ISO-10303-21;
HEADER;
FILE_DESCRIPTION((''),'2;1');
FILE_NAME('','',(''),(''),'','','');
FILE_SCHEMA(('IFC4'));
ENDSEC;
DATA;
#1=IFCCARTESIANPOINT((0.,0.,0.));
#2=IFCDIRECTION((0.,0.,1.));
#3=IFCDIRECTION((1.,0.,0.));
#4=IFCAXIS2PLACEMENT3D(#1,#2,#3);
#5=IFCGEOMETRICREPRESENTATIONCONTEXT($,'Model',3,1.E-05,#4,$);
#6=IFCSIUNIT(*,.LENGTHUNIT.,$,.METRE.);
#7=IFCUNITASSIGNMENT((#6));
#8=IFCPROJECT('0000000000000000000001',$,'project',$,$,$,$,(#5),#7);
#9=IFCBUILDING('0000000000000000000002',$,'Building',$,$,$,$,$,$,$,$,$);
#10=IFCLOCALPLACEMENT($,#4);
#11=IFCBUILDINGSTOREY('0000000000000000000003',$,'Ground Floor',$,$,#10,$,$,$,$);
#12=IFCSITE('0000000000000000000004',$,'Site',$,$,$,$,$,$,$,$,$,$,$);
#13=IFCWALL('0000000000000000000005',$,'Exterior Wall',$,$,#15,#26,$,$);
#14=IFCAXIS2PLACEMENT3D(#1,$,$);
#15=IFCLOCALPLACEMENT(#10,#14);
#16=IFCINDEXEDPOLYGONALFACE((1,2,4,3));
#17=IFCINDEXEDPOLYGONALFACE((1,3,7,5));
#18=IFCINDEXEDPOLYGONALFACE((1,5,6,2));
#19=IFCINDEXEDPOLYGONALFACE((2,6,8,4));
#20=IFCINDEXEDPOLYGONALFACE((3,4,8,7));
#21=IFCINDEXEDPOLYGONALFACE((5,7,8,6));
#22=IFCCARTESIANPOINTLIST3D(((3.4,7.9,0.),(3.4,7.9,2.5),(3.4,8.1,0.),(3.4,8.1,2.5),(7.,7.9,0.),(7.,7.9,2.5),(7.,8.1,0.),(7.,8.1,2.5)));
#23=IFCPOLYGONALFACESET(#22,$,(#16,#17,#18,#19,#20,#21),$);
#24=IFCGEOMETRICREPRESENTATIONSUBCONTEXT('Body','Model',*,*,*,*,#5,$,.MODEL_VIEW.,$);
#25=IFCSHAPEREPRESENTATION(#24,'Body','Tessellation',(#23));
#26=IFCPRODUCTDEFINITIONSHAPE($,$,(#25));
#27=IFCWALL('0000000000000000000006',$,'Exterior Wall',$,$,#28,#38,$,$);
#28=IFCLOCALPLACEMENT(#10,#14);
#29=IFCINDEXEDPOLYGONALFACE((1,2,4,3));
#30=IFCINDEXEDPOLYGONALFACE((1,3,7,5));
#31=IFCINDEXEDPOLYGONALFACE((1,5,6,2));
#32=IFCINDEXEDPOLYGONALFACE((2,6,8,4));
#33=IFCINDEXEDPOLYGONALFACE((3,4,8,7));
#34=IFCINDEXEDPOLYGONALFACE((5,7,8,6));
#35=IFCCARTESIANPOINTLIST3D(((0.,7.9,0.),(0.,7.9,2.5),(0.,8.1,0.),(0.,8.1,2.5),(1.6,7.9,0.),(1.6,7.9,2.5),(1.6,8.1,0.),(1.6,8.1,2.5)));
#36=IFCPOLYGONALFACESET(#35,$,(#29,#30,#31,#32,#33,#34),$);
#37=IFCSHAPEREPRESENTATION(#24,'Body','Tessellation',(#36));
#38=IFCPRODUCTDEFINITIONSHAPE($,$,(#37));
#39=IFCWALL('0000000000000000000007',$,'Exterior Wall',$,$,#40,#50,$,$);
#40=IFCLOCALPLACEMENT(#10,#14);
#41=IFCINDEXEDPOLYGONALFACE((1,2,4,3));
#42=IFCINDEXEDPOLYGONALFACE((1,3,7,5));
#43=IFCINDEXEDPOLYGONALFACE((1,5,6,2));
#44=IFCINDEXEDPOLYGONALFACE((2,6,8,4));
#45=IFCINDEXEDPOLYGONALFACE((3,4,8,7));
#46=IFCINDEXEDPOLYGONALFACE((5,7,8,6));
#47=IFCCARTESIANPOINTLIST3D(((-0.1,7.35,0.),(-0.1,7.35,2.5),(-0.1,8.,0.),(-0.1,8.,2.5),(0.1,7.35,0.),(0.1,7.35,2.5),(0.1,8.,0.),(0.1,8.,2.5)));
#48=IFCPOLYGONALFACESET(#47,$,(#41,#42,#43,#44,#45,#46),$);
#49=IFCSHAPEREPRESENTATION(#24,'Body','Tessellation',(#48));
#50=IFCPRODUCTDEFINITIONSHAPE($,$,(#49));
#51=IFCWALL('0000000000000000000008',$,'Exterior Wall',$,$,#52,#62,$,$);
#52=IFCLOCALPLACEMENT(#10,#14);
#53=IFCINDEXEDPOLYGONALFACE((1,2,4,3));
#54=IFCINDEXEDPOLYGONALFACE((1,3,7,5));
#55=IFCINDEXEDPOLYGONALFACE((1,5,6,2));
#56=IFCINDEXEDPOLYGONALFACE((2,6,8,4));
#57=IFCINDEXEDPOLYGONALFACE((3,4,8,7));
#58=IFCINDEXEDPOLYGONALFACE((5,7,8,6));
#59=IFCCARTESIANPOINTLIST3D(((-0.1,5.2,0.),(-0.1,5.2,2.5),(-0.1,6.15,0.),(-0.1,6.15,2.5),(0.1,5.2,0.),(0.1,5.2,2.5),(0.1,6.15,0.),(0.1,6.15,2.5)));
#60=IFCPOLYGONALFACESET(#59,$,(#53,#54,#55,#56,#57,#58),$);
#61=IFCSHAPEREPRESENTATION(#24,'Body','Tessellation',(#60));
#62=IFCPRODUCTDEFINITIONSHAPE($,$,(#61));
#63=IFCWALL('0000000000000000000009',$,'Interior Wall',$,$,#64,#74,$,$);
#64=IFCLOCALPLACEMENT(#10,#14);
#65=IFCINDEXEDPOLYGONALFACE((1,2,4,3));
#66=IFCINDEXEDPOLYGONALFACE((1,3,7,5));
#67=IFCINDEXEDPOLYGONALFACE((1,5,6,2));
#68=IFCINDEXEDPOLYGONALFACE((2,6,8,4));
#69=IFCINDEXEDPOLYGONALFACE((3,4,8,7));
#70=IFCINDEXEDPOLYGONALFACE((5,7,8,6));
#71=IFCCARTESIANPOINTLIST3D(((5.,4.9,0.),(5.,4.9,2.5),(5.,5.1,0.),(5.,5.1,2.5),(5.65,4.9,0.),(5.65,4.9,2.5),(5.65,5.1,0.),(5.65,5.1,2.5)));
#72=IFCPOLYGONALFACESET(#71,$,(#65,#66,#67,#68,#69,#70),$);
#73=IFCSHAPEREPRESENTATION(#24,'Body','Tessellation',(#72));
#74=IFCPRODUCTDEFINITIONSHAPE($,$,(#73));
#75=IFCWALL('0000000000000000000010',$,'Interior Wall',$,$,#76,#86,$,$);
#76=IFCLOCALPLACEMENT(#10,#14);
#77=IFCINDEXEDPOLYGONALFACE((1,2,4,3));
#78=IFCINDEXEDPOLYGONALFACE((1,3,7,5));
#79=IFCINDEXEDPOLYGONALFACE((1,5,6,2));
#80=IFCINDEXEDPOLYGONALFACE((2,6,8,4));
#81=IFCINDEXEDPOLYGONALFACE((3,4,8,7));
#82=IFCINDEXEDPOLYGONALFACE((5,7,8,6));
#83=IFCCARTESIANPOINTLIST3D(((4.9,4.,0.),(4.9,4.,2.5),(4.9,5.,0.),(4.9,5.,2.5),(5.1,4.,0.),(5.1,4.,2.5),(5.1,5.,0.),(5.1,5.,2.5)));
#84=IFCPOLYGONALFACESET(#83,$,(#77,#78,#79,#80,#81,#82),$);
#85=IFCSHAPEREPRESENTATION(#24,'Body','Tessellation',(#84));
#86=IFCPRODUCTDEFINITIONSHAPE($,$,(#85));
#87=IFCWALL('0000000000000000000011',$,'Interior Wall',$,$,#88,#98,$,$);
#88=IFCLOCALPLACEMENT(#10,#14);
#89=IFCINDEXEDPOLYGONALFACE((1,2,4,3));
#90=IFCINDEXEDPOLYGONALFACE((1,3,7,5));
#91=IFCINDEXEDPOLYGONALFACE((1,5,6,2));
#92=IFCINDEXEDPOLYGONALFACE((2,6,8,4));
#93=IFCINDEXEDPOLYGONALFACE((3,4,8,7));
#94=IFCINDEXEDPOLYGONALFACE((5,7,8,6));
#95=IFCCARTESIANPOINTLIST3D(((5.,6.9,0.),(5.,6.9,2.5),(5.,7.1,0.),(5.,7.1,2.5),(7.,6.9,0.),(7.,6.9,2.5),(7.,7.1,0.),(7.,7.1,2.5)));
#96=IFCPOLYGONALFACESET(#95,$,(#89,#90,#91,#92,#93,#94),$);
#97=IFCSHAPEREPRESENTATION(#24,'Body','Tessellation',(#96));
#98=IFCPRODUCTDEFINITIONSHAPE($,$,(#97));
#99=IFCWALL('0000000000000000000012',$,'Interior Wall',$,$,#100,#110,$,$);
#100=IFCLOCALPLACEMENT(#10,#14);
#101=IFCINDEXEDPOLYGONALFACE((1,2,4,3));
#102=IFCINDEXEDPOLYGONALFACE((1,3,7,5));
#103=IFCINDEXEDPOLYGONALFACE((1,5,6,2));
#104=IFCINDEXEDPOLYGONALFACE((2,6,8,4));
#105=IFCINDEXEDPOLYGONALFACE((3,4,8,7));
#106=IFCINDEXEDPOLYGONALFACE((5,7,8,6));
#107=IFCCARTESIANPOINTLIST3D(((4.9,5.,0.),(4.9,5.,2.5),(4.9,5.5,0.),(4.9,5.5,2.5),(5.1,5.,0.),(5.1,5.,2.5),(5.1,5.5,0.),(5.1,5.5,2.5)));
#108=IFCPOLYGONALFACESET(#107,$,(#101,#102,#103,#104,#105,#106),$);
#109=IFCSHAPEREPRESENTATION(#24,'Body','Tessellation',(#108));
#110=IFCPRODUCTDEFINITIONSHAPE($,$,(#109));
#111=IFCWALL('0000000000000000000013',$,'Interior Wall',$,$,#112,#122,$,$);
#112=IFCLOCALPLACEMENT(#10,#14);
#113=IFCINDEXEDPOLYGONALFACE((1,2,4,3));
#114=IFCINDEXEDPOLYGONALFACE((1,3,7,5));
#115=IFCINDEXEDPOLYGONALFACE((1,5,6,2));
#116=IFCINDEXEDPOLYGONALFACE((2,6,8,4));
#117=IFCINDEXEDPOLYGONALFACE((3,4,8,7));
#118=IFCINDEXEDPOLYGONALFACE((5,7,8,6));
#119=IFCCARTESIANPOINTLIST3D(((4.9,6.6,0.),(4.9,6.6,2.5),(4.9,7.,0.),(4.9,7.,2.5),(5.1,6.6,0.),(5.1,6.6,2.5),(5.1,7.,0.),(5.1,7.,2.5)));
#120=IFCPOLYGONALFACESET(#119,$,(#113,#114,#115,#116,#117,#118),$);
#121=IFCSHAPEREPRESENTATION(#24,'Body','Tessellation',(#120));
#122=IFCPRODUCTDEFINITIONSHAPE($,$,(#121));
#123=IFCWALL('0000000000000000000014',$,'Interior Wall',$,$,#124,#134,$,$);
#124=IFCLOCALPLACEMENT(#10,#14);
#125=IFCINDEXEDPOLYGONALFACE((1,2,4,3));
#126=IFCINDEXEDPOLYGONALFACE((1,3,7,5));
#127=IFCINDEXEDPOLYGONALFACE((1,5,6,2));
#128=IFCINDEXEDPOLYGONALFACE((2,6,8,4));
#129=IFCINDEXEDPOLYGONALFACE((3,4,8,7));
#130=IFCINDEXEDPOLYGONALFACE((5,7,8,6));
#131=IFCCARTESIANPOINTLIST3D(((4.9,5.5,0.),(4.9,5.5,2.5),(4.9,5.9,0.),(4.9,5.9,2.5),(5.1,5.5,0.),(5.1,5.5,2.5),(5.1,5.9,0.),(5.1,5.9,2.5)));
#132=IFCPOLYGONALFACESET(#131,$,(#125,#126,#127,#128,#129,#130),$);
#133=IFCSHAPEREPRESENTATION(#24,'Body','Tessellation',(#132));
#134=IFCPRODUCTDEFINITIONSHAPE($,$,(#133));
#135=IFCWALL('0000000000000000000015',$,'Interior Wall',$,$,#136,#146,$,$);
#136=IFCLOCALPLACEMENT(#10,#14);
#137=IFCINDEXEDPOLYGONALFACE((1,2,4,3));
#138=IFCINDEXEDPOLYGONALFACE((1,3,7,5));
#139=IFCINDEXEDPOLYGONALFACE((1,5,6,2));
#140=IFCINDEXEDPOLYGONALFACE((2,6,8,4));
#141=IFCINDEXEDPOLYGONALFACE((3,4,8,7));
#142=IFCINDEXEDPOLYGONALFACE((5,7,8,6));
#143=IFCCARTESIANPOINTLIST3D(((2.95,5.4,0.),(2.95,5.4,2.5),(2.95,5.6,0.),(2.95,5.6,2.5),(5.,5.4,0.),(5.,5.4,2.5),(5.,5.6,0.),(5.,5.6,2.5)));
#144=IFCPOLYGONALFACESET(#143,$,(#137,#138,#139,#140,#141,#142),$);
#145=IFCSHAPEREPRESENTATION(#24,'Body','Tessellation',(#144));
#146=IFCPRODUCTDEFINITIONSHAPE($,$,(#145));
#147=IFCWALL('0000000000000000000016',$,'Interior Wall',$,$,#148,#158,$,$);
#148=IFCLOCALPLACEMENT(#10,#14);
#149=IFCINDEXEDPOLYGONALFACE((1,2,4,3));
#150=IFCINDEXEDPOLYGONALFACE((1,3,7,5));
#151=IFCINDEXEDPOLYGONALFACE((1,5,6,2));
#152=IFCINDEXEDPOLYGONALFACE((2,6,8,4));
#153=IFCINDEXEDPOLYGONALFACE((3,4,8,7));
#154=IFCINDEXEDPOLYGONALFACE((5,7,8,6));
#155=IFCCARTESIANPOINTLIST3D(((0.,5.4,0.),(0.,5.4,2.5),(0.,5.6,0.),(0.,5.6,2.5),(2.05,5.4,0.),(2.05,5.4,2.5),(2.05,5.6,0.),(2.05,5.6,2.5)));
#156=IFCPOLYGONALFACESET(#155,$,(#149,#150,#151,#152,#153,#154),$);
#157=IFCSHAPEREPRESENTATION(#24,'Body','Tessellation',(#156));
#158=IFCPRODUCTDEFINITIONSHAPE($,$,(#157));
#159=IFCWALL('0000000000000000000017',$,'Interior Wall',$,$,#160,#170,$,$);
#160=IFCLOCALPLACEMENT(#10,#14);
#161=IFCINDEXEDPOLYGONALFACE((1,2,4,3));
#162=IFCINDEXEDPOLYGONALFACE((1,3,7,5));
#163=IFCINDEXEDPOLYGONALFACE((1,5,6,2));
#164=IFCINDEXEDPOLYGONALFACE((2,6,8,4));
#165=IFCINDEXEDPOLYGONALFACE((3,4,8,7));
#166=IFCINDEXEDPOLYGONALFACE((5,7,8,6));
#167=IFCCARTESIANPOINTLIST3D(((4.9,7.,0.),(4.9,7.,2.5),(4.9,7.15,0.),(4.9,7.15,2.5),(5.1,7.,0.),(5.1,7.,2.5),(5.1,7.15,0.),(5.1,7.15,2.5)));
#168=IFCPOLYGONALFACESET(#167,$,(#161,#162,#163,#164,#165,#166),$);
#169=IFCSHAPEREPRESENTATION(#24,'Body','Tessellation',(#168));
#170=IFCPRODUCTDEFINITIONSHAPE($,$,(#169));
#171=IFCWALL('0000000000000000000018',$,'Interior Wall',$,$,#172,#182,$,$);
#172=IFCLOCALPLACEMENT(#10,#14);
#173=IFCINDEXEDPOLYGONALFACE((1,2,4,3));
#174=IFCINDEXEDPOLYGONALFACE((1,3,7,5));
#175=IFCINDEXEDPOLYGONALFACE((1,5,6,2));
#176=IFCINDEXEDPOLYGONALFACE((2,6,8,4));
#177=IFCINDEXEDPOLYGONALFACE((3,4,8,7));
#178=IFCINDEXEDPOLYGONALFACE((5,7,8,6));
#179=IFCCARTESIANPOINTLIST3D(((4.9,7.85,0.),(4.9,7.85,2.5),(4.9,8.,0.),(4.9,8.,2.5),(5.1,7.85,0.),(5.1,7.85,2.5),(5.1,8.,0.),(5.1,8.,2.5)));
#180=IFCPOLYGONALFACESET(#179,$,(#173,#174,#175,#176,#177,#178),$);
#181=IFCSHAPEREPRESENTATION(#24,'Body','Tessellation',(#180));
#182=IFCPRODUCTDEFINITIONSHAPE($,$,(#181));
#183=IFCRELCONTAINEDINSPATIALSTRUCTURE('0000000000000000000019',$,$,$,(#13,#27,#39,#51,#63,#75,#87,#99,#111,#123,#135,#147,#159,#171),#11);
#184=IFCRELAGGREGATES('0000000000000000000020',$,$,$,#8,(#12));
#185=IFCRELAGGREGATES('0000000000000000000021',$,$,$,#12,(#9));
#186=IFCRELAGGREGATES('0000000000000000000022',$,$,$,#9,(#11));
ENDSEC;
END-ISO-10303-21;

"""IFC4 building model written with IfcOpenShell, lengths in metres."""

from ifc_helpers import new_model, si_unit, frame, origin_with_axes, place, context, subcontext, project, spatial, indexed_curve, outline, extrude, element, save


model = new_model("IFC4")

# Units and contexts
model_context = context("Model", 3, precision=1e-05, world=origin_with_axes())
body_context = subcontext(model_context, "Body", "Model", "MODEL_VIEW")
ifc_project = project(units=[si_unit("LENGTHUNIT", "METRE")], contexts=[model_context])

# Site, building, storey
site = spatial("IfcSite", under=ifc_project, Name="Site")
building = spatial("IfcBuilding", under=site, Name="Building")
storey_placement = place(None, origin_with_axes())
storey = spatial("IfcBuildingStorey", under=building, at=storey_placement, Name="Ground Floor")

# Walls
wall_1_placement = place(storey_placement, frame((7.0, 8.0, 0.0), z_axis=(0.0, 0.0, 1.0), x_axis=(-1.0, 0.0, 0.0)))
element("IfcWall", 1, at=wall_1_placement, inside=storey, Name="Exterior Wall", context=body_context, shape_type="SweptSolid", body=[
    extrude(outline(indexed_curve([(0.0, 0.0), (0.0, 0.2), (3.6, 0.2), (3.6, 0.0), (0.0, 0.0)], self_intersect=False)), frame((0.0, -0.1, 0.0), z_axis=(0.0, 0.0, 1.0), x_axis=(1.0, 0.0, 0.0)), (0.0, 0.0, 1.0), 2.5),
])
wall_2_placement = place(storey_placement, frame((1.6, 8.0, 0.0), z_axis=(0.0, 0.0, 1.0), x_axis=(-1.0, 0.0, 0.0)))
element("IfcWall", 2, at=wall_2_placement, inside=storey, Name="Exterior Wall", context=body_context, shape_type="SweptSolid", body=[
    extrude(outline(indexed_curve([(0.0, 0.0), (0.0, 0.2), (1.6, 0.2), (1.6, 0.0), (0.0, 0.0)], self_intersect=False)), frame((0.0, -0.1, 0.0), z_axis=(0.0, 0.0, 1.0), x_axis=(1.0, 0.0, 0.0)), (0.0, 0.0, 1.0), 2.5),
])
wall_3_placement = place(storey_placement, frame((0.0, 8.0, 0.0), z_axis=(0.0, 0.0, 1.0), x_axis=(0.0, -1.0, 0.0)))
element("IfcWall", 3, at=wall_3_placement, inside=storey, Name="Exterior Wall", context=body_context, shape_type="SweptSolid", body=[
    extrude(outline(indexed_curve([(0.0, 0.0), (0.0, 0.2), (0.65, 0.2), (0.65, 0.0), (0.0, 0.0)], self_intersect=False)), frame((0.0, -0.1, 0.0), z_axis=(0.0, 0.0, 1.0), x_axis=(1.0, 0.0, 0.0)), (0.0, 0.0, 1.0), 2.5),
])
wall_4_placement = place(storey_placement, frame((0.0, 6.15, 0.0), z_axis=(0.0, 0.0, 1.0), x_axis=(0.0, -1.0, 0.0)))
element("IfcWall", 4, at=wall_4_placement, inside=storey, Name="Exterior Wall", context=body_context, shape_type="SweptSolid", body=[
    extrude(outline(indexed_curve([(0.0, 0.0), (0.0, 0.2), (0.95, 0.2), (0.95, 0.0), (0.0, 0.0)], self_intersect=False)), frame((0.0, -0.1, 0.0), z_axis=(0.0, 0.0, 1.0), x_axis=(1.0, 0.0, 0.0)), (0.0, 0.0, 1.0), 2.5),
])
wall_5_placement = place(storey_placement, frame((5.65, 5.0, 0.0), z_axis=(0.0, 0.0, 1.0), x_axis=(-1.0, 0.0, 0.0)))
element("IfcWall", 5, at=wall_5_placement, inside=storey, Name="Interior Wall", context=body_context, shape_type="SweptSolid", body=[
    extrude(outline(indexed_curve([(0.0, 0.0), (0.0, 0.2), (0.65, 0.2), (0.65, 0.0), (0.0, 0.0)], self_intersect=False)), frame((0.0, -0.1, 0.0), z_axis=(0.0, 0.0, 1.0), x_axis=(1.0, 0.0, 0.0)), (0.0, 0.0, 1.0), 2.5),
])
wall_6_placement = place(storey_placement, frame((5.0, 5.0, 0.0), z_axis=(0.0, 0.0, 1.0), x_axis=(0.0, -1.0, 0.0)))
element("IfcWall", 6, at=wall_6_placement, inside=storey, Name="Interior Wall", context=body_context, shape_type="SweptSolid", body=[
    extrude(outline(indexed_curve([(0.0, 0.0), (0.0, 0.2), (1.0, 0.2), (1.0, 0.0), (0.0, 0.0)], self_intersect=False)), frame((0.0, -0.1, 0.0), z_axis=(0.0, 0.0, 1.0), x_axis=(1.0, 0.0, 0.0)), (0.0, 0.0, 1.0), 2.5),
])
wall_7_placement = place(storey_placement, frame((7.0, 7.0, 0.0), z_axis=(0.0, 0.0, 1.0), x_axis=(-1.0, 0.0, 0.0)))
element("IfcWall", 7, at=wall_7_placement, inside=storey, Name="Interior Wall", context=body_context, shape_type="SweptSolid", body=[
    extrude(outline(indexed_curve([(0.0, 0.0), (0.0, 0.2), (2.0, 0.2), (2.0, 0.0), (0.0, 0.0)], self_intersect=False)), frame((0.0, -0.1, 0.0), z_axis=(0.0, 0.0, 1.0), x_axis=(1.0, 0.0, 0.0)), (0.0, 0.0, 1.0), 2.5),
])
wall_8_placement = place(storey_placement, frame((5.0, 5.5, 0.0), z_axis=(0.0, 0.0, 1.0), x_axis=(0.0, -1.0, 0.0)))
element("IfcWall", 8, at=wall_8_placement, inside=storey, Name="Interior Wall", context=body_context, shape_type="SweptSolid", body=[
    extrude(outline(indexed_curve([(0.0, 0.0), (0.0, 0.2), (0.5, 0.2), (0.5, 0.0), (0.0, 0.0)], self_intersect=False)), frame((0.0, -0.1, 0.0), z_axis=(0.0, 0.0, 1.0), x_axis=(1.0, 0.0, 0.0)), (0.0, 0.0, 1.0), 2.5),
])
for number, where, z_axis, x_axis, name in (
    (9, (5.0, 7.0, 0.0), (0.0, 0.0, 1.0), (0.0, -1.0, 0.0), "Interior Wall"),
    (10, (5.0, 5.9, 0.0), (0.0, 0.0, 1.0), (0.0, -1.0, 0.0), "Interior Wall"),
):
    element("IfcWall", number, at=place(storey_placement, frame(where, z_axis=z_axis, x_axis=x_axis)), inside=storey, Name=name, context=body_context, shape_type="SweptSolid", body=[
        extrude(outline(indexed_curve([(0.0, 0.0), (0.0, 0.2), (0.4, 0.2), (0.4, 0.0), (0.0, 0.0)], self_intersect=False)), frame((0.0, -0.1, 0.0), z_axis=(0.0, 0.0, 1.0), x_axis=(1.0, 0.0, 0.0)), (0.0, 0.0, 1.0), 2.5),
    ])
for number, where, z_axis, x_axis, name in (
    (11, (5.0, 5.5, 0.0), (0.0, 0.0, 1.0), (-1.0, 0.0, 0.0), "Interior Wall"),
    (12, (2.05, 5.5, 0.0), (0.0, 0.0, 1.0), (-1.0, 0.0, 0.0), "Interior Wall"),
):
    element("IfcWall", number, at=place(storey_placement, frame(where, z_axis=z_axis, x_axis=x_axis)), inside=storey, Name=name, context=body_context, shape_type="SweptSolid", body=[
        extrude(outline(indexed_curve([(0.0, 0.0), (0.0, 0.2), (2.05, 0.2), (2.05, 0.0), (0.0, 0.0)], self_intersect=False)), frame((0.0, -0.1, 0.0), z_axis=(0.0, 0.0, 1.0), x_axis=(1.0, 0.0, 0.0)), (0.0, 0.0, 1.0), 2.5),
    ])
for number, where, z_axis, x_axis, name in (
    (13, (5.0, 7.0, 0.0), (0.0, 0.0, 1.0), (0.0, 1.0, 0.0), "Interior Wall"),
    (14, (5.0, 7.85, 0.0), (0.0, 0.0, 1.0), (0.0, 1.0, 0.0), "Interior Wall"),
):
    element("IfcWall", number, at=place(storey_placement, frame(where, z_axis=z_axis, x_axis=x_axis)), inside=storey, Name=name, context=body_context, shape_type="SweptSolid", body=[
        extrude(outline(indexed_curve([(0.0, 0.0), (0.0, 0.2), (0.15, 0.2), (0.15, 0.0), (0.0, 0.0)], self_intersect=False)), frame((0.0, -0.1, 0.0), z_axis=(0.0, 0.0, 1.0), x_axis=(1.0, 0.0, 0.0)), (0.0, 0.0, 1.0), 2.5),
    ])

save(model, "model.ifc")
